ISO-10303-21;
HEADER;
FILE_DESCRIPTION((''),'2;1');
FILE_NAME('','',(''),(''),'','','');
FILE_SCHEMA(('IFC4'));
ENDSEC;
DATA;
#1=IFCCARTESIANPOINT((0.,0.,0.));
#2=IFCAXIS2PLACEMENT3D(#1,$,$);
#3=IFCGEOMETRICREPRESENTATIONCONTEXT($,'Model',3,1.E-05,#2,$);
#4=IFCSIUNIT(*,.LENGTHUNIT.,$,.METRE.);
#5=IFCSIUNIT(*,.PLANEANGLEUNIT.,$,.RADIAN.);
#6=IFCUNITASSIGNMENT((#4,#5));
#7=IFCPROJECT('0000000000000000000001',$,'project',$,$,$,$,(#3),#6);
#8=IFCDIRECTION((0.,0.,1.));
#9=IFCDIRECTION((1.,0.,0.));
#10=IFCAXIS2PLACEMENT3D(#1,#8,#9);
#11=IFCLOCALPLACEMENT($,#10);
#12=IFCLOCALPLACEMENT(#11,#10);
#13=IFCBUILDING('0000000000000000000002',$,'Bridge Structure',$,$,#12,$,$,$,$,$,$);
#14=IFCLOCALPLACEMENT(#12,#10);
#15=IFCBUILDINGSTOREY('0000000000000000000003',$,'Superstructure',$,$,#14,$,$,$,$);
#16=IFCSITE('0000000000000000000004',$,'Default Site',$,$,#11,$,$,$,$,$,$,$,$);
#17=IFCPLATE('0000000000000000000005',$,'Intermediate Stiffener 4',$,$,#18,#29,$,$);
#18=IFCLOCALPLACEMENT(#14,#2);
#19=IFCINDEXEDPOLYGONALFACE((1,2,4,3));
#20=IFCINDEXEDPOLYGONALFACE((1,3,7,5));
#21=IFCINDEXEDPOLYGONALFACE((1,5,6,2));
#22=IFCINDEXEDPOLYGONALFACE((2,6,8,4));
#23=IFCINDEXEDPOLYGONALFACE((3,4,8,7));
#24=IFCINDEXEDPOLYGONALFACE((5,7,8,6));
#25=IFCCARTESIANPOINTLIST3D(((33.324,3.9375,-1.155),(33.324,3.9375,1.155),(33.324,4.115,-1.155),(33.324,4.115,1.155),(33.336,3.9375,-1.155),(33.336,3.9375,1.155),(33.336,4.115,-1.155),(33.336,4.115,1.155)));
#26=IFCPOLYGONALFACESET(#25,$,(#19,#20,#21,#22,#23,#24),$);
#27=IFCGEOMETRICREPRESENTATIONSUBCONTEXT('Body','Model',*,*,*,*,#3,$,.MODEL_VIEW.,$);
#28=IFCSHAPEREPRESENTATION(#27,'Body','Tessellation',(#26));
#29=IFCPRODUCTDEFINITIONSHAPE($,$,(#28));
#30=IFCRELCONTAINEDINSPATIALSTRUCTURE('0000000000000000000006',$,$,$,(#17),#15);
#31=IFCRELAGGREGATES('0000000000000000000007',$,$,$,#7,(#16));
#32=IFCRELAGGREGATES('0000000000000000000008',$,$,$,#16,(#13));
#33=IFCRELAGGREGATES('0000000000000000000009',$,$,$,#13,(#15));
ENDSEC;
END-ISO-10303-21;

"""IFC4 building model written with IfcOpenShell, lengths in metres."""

from ifc_helpers import new_model, si_unit, frame, origin, origin_with_axes, origin_2d_with_axis, place, context, subcontext, project, spatial, rectangle, extrude, element, save


model = new_model("IFC4")

# Units and contexts
model_context = context("Model", 3, precision=1e-05, world=origin())
body_context = subcontext(model_context, "Body", "Model", "MODEL_VIEW")
ifc_project = project(units=[si_unit("LENGTHUNIT", "METRE"), si_unit("PLANEANGLEUNIT", "RADIAN")], contexts=[model_context])

# Site, building, storey
site_placement = place(None, origin_with_axes())
site = spatial("IfcSite", under=ifc_project, at=site_placement, Name="Default Site")
building_placement = place(site_placement, origin_with_axes())
building = spatial("IfcBuilding", under=site, at=building_placement, Name="Bridge Structure")
storey_placement = place(building_placement, origin_with_axes())
storey = spatial("IfcBuildingStorey", under=building, at=storey_placement, Name="Superstructure")

# Plate
for number, where, z_axis, x_axis, name in (
    (1, (33.33, 4.0263, -1.155), (0.0, 0.0, 1.0), (1.0, 0.0, 0.0), "Intermediate Stiffener 4"),
):
    element("IfcPlate", number, at=place(storey_placement, frame(where, z_axis=z_axis, x_axis=x_axis)), inside=storey, Name=name, context=body_context, shape_type="SweptSolid", body=[
        extrude(rectangle(XDim=0.012, YDim=0.1775, at=origin_2d_with_axis()), origin_with_axes(), (0.0, 0.0, 1.0), 2.31),
    ])

save(model, "model.ifc")
